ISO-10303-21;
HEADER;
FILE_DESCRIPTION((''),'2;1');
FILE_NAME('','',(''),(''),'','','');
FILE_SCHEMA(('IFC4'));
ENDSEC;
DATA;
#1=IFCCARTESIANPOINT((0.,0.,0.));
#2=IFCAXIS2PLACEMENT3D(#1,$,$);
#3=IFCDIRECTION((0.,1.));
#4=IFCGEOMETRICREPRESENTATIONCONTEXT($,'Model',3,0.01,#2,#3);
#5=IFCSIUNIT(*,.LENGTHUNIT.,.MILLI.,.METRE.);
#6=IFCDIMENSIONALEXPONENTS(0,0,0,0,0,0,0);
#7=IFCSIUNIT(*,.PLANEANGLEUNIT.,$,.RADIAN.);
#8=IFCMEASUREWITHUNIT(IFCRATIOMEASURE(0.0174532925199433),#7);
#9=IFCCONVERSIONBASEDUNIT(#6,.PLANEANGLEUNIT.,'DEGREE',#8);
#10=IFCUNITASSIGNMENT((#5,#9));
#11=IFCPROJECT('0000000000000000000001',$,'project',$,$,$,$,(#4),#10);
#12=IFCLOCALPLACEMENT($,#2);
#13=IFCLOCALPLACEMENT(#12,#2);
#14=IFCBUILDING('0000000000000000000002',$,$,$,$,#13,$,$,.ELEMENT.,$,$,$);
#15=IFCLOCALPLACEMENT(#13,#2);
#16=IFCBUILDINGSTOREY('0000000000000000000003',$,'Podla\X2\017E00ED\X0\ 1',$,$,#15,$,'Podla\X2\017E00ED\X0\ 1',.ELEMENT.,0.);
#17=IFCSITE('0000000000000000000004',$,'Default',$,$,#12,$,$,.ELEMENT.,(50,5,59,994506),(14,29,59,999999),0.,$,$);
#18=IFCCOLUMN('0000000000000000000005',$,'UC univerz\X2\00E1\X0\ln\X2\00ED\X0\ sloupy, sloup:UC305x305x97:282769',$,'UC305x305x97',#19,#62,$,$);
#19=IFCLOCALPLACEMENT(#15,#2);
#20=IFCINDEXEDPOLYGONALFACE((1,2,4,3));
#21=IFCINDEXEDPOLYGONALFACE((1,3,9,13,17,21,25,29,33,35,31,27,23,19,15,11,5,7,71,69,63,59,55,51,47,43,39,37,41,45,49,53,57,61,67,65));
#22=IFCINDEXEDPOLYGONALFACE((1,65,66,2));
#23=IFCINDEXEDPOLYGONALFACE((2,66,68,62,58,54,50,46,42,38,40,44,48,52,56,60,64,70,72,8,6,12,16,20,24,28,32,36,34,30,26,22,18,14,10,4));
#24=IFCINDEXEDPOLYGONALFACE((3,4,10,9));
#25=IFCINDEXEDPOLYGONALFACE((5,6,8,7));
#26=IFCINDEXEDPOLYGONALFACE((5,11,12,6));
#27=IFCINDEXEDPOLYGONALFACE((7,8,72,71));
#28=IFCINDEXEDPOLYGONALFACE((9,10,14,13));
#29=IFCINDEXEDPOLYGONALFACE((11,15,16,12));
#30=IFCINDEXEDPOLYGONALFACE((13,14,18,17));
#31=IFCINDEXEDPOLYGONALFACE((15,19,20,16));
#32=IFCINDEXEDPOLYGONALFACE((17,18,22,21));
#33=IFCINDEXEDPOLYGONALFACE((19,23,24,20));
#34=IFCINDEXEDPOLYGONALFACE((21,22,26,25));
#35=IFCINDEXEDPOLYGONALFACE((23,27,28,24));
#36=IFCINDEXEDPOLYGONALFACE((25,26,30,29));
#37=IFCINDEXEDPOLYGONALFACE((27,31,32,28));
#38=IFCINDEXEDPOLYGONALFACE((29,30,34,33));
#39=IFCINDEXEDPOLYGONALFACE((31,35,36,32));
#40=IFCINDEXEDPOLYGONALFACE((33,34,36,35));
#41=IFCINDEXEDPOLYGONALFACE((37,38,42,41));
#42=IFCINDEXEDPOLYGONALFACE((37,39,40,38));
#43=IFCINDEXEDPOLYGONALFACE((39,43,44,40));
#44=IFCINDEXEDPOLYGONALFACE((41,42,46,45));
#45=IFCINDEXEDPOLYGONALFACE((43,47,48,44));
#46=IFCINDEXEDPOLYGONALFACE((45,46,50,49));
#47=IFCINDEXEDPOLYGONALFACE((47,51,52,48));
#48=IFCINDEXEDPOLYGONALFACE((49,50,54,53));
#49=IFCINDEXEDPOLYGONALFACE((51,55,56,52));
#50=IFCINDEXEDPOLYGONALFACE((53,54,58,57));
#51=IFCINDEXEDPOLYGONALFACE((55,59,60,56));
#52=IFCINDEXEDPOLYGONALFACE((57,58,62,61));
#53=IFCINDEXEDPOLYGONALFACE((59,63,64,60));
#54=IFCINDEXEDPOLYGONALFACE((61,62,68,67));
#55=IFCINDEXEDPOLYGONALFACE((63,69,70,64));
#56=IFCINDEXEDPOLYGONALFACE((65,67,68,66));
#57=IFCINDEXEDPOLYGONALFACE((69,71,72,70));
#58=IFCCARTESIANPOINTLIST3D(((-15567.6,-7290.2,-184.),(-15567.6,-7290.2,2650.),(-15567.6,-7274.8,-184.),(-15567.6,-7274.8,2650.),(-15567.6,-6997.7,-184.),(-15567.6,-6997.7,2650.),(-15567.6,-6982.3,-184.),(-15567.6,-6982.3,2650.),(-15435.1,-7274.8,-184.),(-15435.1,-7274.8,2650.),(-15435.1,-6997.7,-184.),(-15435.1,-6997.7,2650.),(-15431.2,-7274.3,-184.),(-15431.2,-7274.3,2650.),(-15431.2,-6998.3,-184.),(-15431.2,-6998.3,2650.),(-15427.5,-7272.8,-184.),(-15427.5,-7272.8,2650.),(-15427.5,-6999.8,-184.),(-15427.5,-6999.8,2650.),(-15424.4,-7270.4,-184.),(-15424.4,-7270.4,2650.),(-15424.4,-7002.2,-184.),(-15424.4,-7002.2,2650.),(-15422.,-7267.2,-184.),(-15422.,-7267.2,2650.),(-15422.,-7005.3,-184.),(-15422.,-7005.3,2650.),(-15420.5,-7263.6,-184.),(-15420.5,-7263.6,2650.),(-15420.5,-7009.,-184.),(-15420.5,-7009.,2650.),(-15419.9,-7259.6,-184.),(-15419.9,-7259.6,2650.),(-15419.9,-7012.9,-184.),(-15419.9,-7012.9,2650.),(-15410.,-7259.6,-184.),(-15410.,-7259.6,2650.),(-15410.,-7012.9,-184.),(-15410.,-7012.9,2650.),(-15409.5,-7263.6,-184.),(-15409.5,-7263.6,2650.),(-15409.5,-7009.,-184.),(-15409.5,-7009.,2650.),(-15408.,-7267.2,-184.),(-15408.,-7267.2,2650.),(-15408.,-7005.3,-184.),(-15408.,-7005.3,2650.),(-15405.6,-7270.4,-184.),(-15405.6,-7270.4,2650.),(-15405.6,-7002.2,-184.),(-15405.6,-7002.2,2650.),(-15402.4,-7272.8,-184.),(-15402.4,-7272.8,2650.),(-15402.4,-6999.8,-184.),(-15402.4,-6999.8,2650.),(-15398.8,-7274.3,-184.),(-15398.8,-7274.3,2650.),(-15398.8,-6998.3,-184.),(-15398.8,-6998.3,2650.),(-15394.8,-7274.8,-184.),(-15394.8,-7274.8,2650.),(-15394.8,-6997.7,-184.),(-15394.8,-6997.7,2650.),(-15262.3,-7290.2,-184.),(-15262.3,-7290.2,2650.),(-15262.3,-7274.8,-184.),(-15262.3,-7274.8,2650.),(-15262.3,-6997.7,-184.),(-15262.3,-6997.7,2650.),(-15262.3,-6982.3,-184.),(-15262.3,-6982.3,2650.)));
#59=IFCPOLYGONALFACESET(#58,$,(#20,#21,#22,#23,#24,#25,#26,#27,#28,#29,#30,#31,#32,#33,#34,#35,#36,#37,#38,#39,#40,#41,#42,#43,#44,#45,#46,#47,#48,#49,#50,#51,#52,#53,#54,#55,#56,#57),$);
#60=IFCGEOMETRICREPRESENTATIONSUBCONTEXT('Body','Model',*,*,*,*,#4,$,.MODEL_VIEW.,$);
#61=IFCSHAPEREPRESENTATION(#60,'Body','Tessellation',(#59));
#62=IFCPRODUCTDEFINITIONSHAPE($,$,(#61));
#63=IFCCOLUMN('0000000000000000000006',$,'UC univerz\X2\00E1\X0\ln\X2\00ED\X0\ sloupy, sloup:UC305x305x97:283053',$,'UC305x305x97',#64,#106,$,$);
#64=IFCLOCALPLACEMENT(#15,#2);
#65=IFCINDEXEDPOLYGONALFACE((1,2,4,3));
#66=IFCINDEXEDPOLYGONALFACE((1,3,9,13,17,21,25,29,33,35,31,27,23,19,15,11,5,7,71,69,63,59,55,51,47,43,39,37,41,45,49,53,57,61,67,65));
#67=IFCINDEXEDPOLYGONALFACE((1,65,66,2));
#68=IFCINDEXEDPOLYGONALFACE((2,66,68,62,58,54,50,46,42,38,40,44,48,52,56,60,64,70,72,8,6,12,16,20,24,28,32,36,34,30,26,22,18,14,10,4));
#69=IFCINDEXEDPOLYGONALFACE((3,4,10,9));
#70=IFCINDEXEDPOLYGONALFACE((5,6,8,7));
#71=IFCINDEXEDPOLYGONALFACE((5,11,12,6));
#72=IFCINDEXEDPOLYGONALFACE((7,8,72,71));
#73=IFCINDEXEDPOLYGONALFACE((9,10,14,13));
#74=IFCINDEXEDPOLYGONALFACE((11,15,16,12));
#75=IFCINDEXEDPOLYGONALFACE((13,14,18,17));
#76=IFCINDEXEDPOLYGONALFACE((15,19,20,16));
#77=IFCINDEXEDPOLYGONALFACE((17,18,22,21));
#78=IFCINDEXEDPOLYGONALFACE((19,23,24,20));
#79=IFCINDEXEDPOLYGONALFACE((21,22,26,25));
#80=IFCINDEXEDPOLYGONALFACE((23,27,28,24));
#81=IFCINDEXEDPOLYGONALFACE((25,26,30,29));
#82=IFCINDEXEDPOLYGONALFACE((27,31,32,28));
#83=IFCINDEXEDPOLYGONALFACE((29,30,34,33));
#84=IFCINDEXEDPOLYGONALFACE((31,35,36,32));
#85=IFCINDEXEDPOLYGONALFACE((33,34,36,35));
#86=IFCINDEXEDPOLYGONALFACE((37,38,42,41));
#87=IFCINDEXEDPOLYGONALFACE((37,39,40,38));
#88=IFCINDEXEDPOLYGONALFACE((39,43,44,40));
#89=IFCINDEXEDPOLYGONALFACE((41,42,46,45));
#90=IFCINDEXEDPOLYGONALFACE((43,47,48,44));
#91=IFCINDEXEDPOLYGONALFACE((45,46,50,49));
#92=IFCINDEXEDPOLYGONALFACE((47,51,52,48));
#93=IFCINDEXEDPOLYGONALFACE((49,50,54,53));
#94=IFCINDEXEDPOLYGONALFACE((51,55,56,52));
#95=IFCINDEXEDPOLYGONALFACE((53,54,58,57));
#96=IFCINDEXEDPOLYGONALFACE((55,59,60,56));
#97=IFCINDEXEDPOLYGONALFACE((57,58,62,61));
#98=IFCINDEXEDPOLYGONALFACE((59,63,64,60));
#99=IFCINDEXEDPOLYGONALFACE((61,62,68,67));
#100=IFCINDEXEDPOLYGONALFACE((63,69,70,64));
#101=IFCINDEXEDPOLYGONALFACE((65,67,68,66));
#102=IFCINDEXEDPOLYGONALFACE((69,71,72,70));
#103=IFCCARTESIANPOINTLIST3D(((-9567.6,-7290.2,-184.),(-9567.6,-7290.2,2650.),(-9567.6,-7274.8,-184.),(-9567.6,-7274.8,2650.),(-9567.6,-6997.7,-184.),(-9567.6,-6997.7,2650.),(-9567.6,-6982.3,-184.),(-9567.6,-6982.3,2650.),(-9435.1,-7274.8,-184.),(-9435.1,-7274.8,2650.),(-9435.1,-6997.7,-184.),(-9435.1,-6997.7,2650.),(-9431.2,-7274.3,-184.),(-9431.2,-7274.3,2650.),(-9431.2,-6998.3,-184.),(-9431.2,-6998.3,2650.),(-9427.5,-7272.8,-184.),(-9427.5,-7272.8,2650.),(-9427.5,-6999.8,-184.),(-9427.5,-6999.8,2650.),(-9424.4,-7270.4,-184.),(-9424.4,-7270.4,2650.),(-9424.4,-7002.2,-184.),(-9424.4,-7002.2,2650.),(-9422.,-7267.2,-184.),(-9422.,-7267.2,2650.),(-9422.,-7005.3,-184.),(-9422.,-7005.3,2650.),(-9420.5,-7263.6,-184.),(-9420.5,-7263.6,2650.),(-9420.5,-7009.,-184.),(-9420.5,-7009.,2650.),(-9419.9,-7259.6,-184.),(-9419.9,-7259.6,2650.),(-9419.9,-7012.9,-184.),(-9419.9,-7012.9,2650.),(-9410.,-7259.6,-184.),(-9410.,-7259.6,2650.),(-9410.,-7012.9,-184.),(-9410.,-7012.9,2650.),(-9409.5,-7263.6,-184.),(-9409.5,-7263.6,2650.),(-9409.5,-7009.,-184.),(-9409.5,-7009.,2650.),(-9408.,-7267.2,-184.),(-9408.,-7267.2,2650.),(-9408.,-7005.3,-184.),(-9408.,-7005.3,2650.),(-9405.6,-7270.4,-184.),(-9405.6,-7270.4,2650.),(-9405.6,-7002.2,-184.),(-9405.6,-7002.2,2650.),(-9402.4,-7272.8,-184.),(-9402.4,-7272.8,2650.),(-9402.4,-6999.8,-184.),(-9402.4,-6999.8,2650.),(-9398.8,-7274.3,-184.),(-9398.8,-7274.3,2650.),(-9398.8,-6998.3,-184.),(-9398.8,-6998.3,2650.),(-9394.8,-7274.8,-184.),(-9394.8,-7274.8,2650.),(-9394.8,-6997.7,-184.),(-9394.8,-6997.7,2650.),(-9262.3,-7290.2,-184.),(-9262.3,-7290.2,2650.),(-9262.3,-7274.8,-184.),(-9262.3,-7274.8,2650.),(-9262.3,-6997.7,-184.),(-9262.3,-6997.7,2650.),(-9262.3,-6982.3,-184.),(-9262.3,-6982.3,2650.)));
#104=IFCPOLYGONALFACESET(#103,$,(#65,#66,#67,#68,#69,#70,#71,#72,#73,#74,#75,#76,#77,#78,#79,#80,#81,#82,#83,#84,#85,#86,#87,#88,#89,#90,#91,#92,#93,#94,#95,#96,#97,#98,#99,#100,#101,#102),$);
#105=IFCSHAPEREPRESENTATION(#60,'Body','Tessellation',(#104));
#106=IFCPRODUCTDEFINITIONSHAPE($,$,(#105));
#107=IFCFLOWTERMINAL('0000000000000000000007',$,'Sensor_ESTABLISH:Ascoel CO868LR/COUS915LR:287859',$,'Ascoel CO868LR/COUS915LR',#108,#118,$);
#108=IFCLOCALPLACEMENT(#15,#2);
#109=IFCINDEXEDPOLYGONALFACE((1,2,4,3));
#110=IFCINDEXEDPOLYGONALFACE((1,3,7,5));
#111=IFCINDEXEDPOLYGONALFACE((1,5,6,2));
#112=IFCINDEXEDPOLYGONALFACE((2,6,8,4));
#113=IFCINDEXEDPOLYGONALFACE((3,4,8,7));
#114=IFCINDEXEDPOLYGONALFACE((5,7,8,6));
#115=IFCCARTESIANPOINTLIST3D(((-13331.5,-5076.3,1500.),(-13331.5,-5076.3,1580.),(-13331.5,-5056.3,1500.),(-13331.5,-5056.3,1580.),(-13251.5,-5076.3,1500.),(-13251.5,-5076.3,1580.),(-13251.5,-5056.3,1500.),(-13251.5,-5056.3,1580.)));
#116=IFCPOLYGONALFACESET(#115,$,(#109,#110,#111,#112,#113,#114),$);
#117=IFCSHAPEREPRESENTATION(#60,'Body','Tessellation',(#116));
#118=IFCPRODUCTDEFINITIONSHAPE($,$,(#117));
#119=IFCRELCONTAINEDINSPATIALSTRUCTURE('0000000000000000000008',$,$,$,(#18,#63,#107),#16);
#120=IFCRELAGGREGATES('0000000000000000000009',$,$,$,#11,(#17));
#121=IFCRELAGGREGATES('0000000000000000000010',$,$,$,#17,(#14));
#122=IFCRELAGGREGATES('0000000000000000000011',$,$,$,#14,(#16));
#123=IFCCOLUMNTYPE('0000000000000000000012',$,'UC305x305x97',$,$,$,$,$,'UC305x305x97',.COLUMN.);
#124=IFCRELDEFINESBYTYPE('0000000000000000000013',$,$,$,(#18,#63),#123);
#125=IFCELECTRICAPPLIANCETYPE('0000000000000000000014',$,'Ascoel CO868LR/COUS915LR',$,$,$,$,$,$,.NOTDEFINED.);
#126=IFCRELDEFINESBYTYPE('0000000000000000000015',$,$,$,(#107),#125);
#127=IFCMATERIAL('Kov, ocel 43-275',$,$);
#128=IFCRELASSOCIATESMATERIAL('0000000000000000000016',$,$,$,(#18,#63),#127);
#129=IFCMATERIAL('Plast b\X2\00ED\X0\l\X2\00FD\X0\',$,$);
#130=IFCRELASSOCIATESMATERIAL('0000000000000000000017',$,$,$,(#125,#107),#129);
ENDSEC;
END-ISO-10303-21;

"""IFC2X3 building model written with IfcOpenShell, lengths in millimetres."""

from ifc_helpers import new_model, entity, si_unit, converted_unit, direction, frame, origin, origin_2d_with_axis, place, context, subcontext, project, spatial, rectangle, i_section, extrude, source, transform, mapped, material, type_object, type_shapes, element, save


model = new_model("IFC2X3")

# Units and contexts
model_context = context("Model", 3, precision=0.01, world=origin(), true_north=direction((0.0, 1.0)))
body_context = subcontext(model_context, "Body", "Model", "MODEL_VIEW")
ifc_project = project(units=[si_unit("LENGTHUNIT", "METRE", prefix="MILLI"), converted_unit("PLANEANGLEUNIT", "DEGREE", entity("IfcRatioMeasure", 0.0174532925199433), si_unit("PLANEANGLEUNIT", "RADIAN"), dimensions=[0, 0, 0, 0, 0, 0, 0])], contexts=[model_context])

# Site, building, storey
site_placement = place(None, origin())
site = spatial("IfcSite", under=ifc_project, at=site_placement, Name="Default", CompositionType="ELEMENT", RefLatitude=(50, 5, 59, 994506), RefLongitude=(14, 29, 59, 999999), RefElevation=0.0)
building_placement = place(site_placement, origin())
building = spatial("IfcBuilding", under=site, at=building_placement, CompositionType="ELEMENT")
storey_placement = place(building_placement, origin())
storey = spatial("IfcBuildingStorey", under=building, at=storey_placement, Name="Podlaží 1", LongName="Podlaží 1", CompositionType="ELEMENT", Elevation=0.0)

# Columns
ifc_material_1 = material(Name="Kov, ocel 43-275")
column_type = type_object("IfcColumnType", Name="UC305x305x97", ElementType="UC305x305x97", PredefinedType="COLUMN")
shared_shape_1 = source(origin(), body_context, "Body", "SweptSolid", [
    extrude(i_section(OverallWidth=305.3, OverallDepth=307.9, WebThickness=9.9, FlangeThickness=15.4, FilletRadius=15.2, at=origin_2d_with_axis()), frame((0.0, 0.0, -184.0), z_axis=(0.0, 0.0, 1.0), x_axis=(-1.0, 0.0, 0.0)), (0.0, 0.0, 1.0), 2834.0),
])
type_shapes(column_type, [shared_shape_1])
for number, where, name in (
    (1, (-15415.0, -7136.3, 0.0), "UC univerzální sloupy, sloup:UC305x305x97:282769"),
    (2, (-9415.0, -7136.3, 0.0), "UC univerzální sloupy, sloup:UC305x305x97:283053"),
):
    element("IfcColumn", number, at=place(storey_placement, frame(where)), inside=storey, type_object=column_type, material=ifc_material_1, Name=name, ObjectType="UC305x305x97", context=body_context, shape_type="MappedRepresentation", body=[
        mapped(shared_shape_1, transform((0.0, 0.0, 0.0), scale=1.0)),
    ])

# Flow terminal
ifc_material_2 = material(Name="Plast bílý")
electric_appliance_type = type_object("IfcElectricApplianceType", Name="Ascoel CO868LR/COUS915LR", PredefinedType="NOTDEFINED", material=ifc_material_2)
shared_shape_2 = source(origin(), body_context, "Body", "SweptSolid", [
    extrude(rectangle(XDim=80.0, YDim=20.0, at=origin_2d_with_axis()), frame((0.0, 0.0, 0.0), z_axis=(0.0, 0.0, 1.0), x_axis=(-1.0, 0.0, 0.0)), (0.0, 0.0, 1.0), 80.0),
])
type_shapes(electric_appliance_type, [shared_shape_2])
flow_terminal_placement = place(storey_placement, frame((-13291.5, -5066.3, 1500.0)))
element("IfcFlowTerminal", 3, at=flow_terminal_placement, inside=storey, type_object=electric_appliance_type, material=ifc_material_2, Name="Sensor_ESTABLISH:Ascoel CO868LR/COUS915LR:287859", ObjectType="Ascoel CO868LR/COUS915LR", context=body_context, shape_type="MappedRepresentation", body=[
    mapped(shared_shape_2, transform((0.0, 0.0, 0.0), scale=1.0)),
])

save(model, "model.ifc")
